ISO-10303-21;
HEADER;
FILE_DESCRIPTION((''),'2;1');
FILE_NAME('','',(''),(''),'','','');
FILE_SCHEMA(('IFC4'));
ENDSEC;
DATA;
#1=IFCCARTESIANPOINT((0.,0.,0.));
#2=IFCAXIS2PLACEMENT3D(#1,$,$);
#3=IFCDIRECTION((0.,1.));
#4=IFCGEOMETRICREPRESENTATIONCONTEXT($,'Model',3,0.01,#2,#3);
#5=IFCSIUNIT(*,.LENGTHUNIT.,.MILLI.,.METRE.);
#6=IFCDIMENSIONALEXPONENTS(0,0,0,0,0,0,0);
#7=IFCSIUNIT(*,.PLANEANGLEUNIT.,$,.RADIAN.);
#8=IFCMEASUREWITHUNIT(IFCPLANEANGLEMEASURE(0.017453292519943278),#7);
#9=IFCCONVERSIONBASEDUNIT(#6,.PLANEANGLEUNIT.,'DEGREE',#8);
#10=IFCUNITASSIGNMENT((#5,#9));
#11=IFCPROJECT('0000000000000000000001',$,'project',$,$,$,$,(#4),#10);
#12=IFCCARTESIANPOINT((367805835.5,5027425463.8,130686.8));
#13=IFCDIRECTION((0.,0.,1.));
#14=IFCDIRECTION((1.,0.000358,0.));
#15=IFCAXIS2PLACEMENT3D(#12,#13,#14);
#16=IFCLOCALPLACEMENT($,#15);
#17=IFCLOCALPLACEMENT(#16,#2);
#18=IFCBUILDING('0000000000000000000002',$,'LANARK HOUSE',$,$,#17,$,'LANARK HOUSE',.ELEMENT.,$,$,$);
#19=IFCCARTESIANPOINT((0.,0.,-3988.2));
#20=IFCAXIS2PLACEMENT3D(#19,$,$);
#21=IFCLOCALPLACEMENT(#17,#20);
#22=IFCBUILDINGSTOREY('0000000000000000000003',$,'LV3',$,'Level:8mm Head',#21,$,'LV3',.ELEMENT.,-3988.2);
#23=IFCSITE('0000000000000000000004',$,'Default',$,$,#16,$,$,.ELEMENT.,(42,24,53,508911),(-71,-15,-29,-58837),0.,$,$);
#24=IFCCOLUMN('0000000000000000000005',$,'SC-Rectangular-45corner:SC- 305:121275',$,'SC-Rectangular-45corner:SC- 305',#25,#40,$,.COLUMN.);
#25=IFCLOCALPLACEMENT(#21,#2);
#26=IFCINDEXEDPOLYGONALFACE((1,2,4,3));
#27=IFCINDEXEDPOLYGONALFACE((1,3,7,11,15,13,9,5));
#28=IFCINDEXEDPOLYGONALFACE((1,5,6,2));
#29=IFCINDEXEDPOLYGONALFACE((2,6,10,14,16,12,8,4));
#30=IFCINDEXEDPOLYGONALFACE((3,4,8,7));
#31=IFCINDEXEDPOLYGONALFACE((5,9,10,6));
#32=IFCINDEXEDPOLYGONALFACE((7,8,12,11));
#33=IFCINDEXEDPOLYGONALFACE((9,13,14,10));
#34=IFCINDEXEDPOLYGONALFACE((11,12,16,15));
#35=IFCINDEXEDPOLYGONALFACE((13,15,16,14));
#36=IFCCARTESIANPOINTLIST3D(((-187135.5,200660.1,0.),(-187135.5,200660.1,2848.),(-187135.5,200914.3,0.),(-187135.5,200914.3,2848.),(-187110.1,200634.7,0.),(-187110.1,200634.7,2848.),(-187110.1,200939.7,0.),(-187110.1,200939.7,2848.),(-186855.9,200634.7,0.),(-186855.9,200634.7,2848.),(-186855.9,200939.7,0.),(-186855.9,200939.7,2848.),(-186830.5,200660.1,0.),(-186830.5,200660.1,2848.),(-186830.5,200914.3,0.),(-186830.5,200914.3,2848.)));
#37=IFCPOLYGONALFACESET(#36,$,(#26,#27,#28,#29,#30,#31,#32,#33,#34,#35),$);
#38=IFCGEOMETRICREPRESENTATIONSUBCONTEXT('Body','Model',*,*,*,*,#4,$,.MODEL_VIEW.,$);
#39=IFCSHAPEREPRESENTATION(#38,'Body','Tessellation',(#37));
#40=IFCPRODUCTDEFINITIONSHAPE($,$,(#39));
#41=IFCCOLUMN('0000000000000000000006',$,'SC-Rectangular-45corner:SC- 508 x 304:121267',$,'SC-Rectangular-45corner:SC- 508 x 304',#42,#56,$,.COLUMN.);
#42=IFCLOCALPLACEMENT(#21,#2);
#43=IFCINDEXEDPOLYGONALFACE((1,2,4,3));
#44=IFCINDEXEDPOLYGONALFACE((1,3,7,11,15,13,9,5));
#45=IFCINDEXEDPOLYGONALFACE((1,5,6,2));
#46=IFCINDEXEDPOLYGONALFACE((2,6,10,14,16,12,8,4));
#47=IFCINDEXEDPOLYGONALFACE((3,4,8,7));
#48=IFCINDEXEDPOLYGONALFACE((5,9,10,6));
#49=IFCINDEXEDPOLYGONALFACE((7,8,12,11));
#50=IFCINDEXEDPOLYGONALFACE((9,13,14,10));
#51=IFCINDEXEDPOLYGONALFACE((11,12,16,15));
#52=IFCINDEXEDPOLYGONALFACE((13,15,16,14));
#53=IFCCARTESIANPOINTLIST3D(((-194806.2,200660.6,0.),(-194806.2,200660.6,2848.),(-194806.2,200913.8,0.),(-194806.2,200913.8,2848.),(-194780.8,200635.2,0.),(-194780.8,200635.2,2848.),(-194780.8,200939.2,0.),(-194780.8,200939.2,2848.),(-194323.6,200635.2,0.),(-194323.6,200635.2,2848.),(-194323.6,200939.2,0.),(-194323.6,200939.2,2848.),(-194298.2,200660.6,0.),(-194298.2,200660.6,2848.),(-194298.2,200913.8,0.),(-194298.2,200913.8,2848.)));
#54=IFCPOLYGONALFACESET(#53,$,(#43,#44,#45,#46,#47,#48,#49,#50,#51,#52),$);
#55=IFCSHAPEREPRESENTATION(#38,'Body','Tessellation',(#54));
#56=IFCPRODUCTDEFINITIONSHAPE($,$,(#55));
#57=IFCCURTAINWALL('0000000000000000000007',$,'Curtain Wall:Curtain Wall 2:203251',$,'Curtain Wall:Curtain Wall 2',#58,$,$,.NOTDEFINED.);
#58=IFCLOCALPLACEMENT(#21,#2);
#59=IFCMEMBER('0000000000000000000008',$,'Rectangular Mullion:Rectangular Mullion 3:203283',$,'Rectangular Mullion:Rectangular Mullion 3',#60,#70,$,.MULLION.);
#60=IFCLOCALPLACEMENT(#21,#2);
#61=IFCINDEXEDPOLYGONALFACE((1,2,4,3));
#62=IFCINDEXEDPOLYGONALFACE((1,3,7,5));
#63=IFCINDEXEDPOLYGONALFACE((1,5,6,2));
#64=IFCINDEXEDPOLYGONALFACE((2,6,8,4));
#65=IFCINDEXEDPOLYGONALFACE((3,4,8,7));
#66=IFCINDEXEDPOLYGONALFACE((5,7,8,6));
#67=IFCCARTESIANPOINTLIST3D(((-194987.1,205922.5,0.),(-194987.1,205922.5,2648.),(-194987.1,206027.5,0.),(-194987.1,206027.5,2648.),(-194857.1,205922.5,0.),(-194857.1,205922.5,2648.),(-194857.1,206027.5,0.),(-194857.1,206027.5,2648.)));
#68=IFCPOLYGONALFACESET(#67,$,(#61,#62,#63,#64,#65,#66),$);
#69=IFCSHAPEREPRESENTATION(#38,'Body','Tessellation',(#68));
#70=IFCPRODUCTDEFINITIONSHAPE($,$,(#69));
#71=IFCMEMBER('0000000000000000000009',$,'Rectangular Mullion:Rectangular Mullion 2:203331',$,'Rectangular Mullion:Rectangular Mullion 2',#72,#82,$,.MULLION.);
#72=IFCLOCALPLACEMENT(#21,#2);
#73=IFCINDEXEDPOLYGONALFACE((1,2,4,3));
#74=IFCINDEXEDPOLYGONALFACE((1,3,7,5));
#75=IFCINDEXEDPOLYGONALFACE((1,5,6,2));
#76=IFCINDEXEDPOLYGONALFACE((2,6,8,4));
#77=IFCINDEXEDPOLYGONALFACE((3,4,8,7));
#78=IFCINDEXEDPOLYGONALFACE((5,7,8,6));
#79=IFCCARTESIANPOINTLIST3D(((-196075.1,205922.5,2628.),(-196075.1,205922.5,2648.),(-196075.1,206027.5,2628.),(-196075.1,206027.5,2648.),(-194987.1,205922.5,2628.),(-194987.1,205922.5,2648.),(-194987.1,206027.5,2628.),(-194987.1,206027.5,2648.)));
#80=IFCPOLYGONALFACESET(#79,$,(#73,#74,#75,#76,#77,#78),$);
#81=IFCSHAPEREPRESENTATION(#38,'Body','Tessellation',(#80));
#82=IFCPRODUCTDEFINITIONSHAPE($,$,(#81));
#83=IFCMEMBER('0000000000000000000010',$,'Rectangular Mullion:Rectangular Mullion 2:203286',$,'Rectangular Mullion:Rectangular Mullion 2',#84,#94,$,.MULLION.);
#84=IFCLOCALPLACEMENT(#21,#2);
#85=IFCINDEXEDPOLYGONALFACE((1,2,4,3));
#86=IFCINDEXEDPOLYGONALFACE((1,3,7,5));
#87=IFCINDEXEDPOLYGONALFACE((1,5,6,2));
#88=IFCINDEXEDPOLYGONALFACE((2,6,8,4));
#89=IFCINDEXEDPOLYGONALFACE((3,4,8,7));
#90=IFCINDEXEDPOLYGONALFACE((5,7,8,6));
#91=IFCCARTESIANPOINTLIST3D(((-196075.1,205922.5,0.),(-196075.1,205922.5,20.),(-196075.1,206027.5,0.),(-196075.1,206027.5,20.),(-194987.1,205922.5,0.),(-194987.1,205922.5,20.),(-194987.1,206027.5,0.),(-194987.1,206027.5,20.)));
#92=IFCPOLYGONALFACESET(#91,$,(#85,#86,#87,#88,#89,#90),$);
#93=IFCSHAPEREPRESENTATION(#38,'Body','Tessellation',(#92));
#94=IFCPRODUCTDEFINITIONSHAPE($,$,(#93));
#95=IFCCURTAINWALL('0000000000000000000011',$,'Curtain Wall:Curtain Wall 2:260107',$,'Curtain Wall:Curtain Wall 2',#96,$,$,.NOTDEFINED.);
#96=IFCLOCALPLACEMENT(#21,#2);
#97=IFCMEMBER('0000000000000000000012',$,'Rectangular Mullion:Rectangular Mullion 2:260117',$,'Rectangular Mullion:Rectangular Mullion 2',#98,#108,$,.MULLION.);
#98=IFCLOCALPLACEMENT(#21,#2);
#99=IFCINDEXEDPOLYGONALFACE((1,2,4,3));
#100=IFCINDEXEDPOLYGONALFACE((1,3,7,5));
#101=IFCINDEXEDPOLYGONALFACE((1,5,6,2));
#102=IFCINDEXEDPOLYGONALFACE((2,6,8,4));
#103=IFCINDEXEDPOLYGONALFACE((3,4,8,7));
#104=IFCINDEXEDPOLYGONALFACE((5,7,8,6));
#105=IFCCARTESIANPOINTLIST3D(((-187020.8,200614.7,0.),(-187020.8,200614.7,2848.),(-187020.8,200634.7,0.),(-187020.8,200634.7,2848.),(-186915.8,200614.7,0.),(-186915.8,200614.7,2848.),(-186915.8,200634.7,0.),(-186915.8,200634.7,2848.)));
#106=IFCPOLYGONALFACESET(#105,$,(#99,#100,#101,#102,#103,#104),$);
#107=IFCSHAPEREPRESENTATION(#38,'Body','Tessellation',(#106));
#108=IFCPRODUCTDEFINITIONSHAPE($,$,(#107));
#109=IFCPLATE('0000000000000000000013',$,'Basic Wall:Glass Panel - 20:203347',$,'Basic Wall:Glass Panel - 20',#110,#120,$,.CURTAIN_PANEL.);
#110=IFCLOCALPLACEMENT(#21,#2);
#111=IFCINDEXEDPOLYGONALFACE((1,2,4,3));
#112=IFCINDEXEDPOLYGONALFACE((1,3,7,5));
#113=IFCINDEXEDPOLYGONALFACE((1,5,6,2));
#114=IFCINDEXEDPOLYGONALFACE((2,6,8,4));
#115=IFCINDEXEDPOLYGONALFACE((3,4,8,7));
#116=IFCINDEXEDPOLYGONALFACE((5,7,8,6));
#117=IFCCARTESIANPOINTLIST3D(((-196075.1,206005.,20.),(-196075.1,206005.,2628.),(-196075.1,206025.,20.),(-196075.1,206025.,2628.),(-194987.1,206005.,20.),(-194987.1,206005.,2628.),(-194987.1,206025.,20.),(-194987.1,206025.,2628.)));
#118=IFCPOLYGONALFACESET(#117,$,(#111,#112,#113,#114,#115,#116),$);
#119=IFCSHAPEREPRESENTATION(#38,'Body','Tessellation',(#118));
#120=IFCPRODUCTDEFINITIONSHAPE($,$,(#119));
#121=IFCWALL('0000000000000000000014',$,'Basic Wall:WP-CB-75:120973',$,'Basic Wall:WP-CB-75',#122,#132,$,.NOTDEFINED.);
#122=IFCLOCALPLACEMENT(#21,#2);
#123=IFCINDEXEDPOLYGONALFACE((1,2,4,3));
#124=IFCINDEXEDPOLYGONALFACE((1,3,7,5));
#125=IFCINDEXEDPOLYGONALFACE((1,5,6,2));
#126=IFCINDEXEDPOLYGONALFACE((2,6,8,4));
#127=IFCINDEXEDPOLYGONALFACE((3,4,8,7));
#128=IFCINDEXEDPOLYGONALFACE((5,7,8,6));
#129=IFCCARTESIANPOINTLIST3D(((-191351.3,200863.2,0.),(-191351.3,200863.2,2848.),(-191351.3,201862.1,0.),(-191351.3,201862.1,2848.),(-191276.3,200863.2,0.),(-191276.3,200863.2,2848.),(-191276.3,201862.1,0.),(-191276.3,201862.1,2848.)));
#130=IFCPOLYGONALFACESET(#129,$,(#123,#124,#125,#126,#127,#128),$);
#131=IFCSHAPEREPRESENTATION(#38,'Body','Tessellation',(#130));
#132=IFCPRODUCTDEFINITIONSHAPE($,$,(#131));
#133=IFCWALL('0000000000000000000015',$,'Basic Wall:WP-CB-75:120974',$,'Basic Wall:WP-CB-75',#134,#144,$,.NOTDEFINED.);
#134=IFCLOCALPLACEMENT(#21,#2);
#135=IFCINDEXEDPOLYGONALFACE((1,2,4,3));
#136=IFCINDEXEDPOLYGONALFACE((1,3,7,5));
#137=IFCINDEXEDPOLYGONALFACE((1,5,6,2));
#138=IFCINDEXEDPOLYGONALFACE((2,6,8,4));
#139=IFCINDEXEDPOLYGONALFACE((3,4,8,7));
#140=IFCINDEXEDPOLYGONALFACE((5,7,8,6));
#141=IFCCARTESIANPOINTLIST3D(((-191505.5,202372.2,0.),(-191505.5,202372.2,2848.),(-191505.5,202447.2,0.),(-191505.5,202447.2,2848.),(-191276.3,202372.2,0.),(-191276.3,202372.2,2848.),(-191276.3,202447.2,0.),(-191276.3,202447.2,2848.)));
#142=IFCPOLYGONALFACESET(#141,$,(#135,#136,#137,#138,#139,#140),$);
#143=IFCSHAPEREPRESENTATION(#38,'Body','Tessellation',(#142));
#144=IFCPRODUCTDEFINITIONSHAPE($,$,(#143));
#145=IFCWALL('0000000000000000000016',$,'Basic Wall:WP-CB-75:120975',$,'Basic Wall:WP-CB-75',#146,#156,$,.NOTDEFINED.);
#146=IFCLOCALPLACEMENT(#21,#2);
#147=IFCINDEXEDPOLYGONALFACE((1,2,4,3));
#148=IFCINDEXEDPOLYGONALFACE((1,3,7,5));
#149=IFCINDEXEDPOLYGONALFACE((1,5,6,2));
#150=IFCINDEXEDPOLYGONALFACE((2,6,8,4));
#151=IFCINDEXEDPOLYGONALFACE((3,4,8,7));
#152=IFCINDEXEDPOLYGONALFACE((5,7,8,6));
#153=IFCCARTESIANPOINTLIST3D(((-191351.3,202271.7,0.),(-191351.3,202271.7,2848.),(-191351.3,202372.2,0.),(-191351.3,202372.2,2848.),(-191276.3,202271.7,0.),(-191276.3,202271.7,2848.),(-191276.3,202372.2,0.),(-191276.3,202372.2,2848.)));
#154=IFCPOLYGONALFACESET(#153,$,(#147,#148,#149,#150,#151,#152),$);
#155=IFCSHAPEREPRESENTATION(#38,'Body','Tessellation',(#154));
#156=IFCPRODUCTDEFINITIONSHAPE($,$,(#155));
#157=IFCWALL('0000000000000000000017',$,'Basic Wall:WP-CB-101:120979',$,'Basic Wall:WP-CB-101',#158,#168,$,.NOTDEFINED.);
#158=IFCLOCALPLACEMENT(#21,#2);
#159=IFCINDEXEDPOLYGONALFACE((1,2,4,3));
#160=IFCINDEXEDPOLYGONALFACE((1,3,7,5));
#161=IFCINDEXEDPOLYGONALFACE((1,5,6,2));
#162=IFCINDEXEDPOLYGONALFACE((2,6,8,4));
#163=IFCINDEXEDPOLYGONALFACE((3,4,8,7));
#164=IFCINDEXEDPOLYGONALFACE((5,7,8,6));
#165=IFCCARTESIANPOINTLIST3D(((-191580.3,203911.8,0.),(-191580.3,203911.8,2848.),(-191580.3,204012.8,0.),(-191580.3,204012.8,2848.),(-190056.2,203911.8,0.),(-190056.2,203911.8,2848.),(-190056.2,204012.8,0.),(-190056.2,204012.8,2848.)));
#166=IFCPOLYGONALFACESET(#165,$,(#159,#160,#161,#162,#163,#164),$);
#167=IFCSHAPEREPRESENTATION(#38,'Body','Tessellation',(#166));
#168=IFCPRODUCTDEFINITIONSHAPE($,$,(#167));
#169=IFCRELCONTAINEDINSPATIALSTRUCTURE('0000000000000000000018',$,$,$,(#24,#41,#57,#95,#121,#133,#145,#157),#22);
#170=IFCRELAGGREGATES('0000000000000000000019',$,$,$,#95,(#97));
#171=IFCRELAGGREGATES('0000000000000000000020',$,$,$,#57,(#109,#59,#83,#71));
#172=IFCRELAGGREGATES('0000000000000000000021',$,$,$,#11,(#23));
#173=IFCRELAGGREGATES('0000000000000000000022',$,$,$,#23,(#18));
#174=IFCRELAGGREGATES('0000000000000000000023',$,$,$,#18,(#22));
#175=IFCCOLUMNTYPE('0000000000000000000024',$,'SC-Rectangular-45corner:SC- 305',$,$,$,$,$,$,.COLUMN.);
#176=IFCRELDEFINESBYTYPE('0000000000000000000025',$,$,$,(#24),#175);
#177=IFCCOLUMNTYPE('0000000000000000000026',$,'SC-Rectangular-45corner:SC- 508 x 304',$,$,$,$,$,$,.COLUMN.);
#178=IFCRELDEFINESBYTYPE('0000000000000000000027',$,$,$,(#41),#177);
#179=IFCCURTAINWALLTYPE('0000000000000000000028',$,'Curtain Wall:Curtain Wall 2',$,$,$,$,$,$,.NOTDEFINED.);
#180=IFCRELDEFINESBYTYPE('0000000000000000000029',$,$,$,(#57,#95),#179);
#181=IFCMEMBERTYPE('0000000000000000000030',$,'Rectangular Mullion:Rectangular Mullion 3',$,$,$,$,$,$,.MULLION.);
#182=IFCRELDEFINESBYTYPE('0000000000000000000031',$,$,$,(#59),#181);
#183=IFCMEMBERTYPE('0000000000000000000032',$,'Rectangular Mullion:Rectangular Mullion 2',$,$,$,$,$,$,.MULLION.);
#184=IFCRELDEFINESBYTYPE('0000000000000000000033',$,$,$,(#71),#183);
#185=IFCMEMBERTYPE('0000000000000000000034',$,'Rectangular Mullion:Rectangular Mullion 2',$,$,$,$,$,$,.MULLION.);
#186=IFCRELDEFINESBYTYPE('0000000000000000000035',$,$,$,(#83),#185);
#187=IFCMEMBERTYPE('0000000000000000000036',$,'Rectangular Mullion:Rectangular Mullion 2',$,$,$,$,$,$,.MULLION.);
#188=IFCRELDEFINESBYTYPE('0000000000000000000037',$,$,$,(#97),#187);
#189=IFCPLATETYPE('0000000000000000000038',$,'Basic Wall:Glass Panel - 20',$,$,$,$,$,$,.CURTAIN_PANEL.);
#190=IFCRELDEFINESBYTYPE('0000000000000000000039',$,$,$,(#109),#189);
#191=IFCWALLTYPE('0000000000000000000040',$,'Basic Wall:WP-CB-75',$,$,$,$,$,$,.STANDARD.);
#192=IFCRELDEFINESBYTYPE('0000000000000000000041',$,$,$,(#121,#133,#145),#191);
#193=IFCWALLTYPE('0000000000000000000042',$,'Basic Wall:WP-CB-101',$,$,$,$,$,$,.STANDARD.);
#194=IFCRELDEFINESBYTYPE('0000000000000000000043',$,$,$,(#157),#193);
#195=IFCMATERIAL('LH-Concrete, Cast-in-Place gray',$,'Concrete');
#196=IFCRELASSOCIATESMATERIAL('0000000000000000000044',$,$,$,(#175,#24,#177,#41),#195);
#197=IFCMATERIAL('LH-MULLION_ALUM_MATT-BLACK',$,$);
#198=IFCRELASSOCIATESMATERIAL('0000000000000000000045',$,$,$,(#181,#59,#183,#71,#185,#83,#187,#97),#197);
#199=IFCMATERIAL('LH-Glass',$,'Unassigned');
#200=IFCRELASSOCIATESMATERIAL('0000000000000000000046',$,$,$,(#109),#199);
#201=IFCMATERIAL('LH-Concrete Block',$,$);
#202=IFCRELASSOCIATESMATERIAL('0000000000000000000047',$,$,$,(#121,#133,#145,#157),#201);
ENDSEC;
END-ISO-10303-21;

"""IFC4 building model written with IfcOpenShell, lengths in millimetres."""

from ifc_helpers import new_model, entity, si_unit, converted_unit, direction, frame, origin, place, context, subcontext, project, spatial, indexed_curve, outline, extrude, source, transform, mapped, material, type_object, type_shapes, element, aggregate, save


model = new_model("IFC4")

# Units and contexts
model_context = context("Model", 3, precision=0.01, world=origin(), true_north=direction((0.0, 1.0)))
body_context = subcontext(model_context, "Body", "Model", "MODEL_VIEW")
ifc_project = project(units=[si_unit("LENGTHUNIT", "METRE", prefix="MILLI"), converted_unit("PLANEANGLEUNIT", "DEGREE", entity("IfcPlaneAngleMeasure", 0.017453292519943278), si_unit("PLANEANGLEUNIT", "RADIAN"), dimensions=[0, 0, 0, 0, 0, 0, 0])], contexts=[model_context])

# Site, building, storey
site_placement = place(None, frame((367805835.5, 5027425463.8, 130686.8), z_axis=(0.0, 0.0, 1.0), x_axis=(1.0, 0.000358, 0.0)))
site = spatial("IfcSite", under=ifc_project, at=site_placement, Name="Default", CompositionType="ELEMENT", RefLatitude=(42, 24, 53, 508911), RefLongitude=(-71, -15, -29, -58837), RefElevation=0.0)
building_placement = place(site_placement, origin())
building = spatial("IfcBuilding", under=site, at=building_placement, Name="LANARK HOUSE", LongName="LANARK HOUSE", CompositionType="ELEMENT")
storey_placement = place(building_placement, frame((0.0, 0.0, -3988.2)))
storey = spatial("IfcBuildingStorey", under=building, at=storey_placement, Name="LV3", ObjectType="Level:8mm Head", LongName="LV3", CompositionType="ELEMENT", Elevation=-3988.2)

# Columns
ifc_material_1 = material(Name="LH-Concrete, Cast-in-Place gray", Category="Concrete")
column_type_1 = type_object("IfcColumnType", Name="SC-Rectangular-45corner:SC- 305", PredefinedType="COLUMN", material=ifc_material_1)
shared_shape_1 = source(origin(), body_context, "Body", "SweptSolid", [
    extrude(outline(indexed_curve([(-127.1, -152.5), (127.1, -152.5), (152.5, -127.1), (152.5, 127.1), (127.1, 152.5), (-127.1, 152.5), (-152.5, 127.1), (-152.5, -127.1), (-127.1, -152.5)], self_intersect=False)), frame((0.0, 0.0, -3988.2), z_axis=(0.0, 0.0, 1.0), x_axis=(-1.0, 0.0, 0.0)), (0.0, 0.0, 1.0), 2848.0),
])
type_shapes(column_type_1, [shared_shape_1])
column_1_placement = place(storey_placement, frame((-186983.0, 200787.2, 3988.2)))
element("IfcColumn", 1, at=column_1_placement, inside=storey, type_object=column_type_1, material=ifc_material_1, Name="SC-Rectangular-45corner:SC- 305:121275", ObjectType="SC-Rectangular-45corner:SC- 305", PredefinedType="COLUMN", context=body_context, shape_type="MappedRepresentation", body=[
    mapped(shared_shape_1, transform((0.0, 0.0, 0.0), scale=1.0)),
])
column_type_2 = type_object("IfcColumnType", Name="SC-Rectangular-45corner:SC- 508 x 304", PredefinedType="COLUMN", material=ifc_material_1)
shared_shape_2 = source(origin(), body_context, "Body", "SweptSolid", [
    extrude(outline(indexed_curve([(-228.6, -152.0), (228.6, -152.0), (254.0, -126.6), (254.0, 126.6), (228.6, 152.0), (-228.6, 152.0), (-254.0, 126.6), (-254.0, -126.6), (-228.6, -152.0)], self_intersect=False)), frame((0.0, 0.0, -3988.2), z_axis=(0.0, 0.0, 1.0), x_axis=(-1.0, 0.0, 0.0)), (0.0, 0.0, 1.0), 2848.0),
])
type_shapes(column_type_2, [shared_shape_2])
column_2_placement = place(storey_placement, frame((-194552.2, 200787.2, 3988.2)))
element("IfcColumn", 2, at=column_2_placement, inside=storey, type_object=column_type_2, material=ifc_material_1, Name="SC-Rectangular-45corner:SC- 508 x 304:121267", ObjectType="SC-Rectangular-45corner:SC- 508 x 304", PredefinedType="COLUMN", context=body_context, shape_type="MappedRepresentation", body=[
    mapped(shared_shape_2, transform((0.0, 0.0, 0.0), scale=1.0)),
])

# Curtain wall, members
curtain_wall_type = type_object("IfcCurtainWallType", Name="Curtain Wall:Curtain Wall 2", PredefinedType="NOTDEFINED")
curtain_wall_1_placement = place(storey_placement, frame((0.0, 0.0, 3988.2)))
curtain_wall_1 = element("IfcCurtainWall", 3, at=curtain_wall_1_placement, inside=storey, type_object=curtain_wall_type, Name="Curtain Wall:Curtain Wall 2:203251", ObjectType="Curtain Wall:Curtain Wall 2", PredefinedType="NOTDEFINED")
ifc_material_2 = material(Name="LH-MULLION_ALUM_MATT-BLACK")
member_type_1 = type_object("IfcMemberType", Name="Rectangular Mullion:Rectangular Mullion 3", PredefinedType="MULLION", material=ifc_material_2)
shared_shape_3 = source(origin(), body_context, "Body", "SweptSolid", [
    extrude(outline(indexed_curve([(-65.0, -52.5), (65.0, -52.5), (65.0, 52.5), (-65.0, 52.5), (-65.0, -52.5)], self_intersect=False)), frame((-65.0, -40.0, -2648.0), z_axis=(0.0, 0.0, 1.0), x_axis=(-1.0, 0.0, 0.0)), (0.0, 0.0, 1.0), 2648.0),
])
type_shapes(member_type_1, [shared_shape_3])
member_1_placement = place(curtain_wall_1_placement, frame((-194857.1, 206015.0, -1340.2)))
member_1 = element("IfcMember", 4, at=member_1_placement, type_object=member_type_1, material=ifc_material_2, Name="Rectangular Mullion:Rectangular Mullion 3:203283", ObjectType="Rectangular Mullion:Rectangular Mullion 3", PredefinedType="MULLION", context=body_context, shape_type="MappedRepresentation", body=[
    mapped(shared_shape_3, transform((0.0, 0.0, 0.0), scale=1.0)),
])
member_type_2 = type_object("IfcMemberType", Name="Rectangular Mullion:Rectangular Mullion 2", PredefinedType="MULLION", material=ifc_material_2)
shared_shape_4 = source(origin(), body_context, "Body", "SweptSolid", [
    extrude(outline(indexed_curve([(-10.0, -52.5), (10.0, -52.5), (10.0, 52.5), (-10.0, 52.5), (-10.0, -52.5)], self_intersect=False)), frame((-10.0, -40.0, -1088.0), z_axis=(0.0, 0.0, 1.0), x_axis=(-1.0, 0.0, 0.0)), (0.0, 0.0, 1.0), 1088.0),
])
type_shapes(member_type_2, [shared_shape_4])
member_2_placement = place(curtain_wall_1_placement, frame((-196075.1, 206015.0, -1340.2), z_axis=(-1.0, 0.0, 0.0), x_axis=(0.0, 0.0, 1.0)))
member_2 = element("IfcMember", 5, at=member_2_placement, type_object=member_type_2, material=ifc_material_2, Name="Rectangular Mullion:Rectangular Mullion 2:203331", ObjectType="Rectangular Mullion:Rectangular Mullion 2", PredefinedType="MULLION", context=body_context, shape_type="MappedRepresentation", body=[
    mapped(shared_shape_4, transform((0.0, 0.0, 0.0), scale=1.0)),
])
member_type_3 = type_object("IfcMemberType", Name="Rectangular Mullion:Rectangular Mullion 2", PredefinedType="MULLION", material=ifc_material_2)
shared_shape_5 = source(origin(), body_context, "Body", "SweptSolid", [
    extrude(outline(indexed_curve([(-10.0, -52.5), (10.0, -52.5), (10.0, 52.5), (-10.0, 52.5), (-10.0, -52.5)], self_intersect=False)), frame((-10.0, -40.0, -1088.0), z_axis=(0.0, 0.0, 1.0), x_axis=(-1.0, 0.0, 0.0)), (0.0, 0.0, 1.0), 1088.0),
])
type_shapes(member_type_3, [shared_shape_5])
member_3_placement = place(curtain_wall_1_placement, frame((-194987.1, 206015.0, -3988.2), z_axis=(1.0, 0.0, 0.0), x_axis=(0.0, 0.0, -1.0)))
member_3 = element("IfcMember", 6, at=member_3_placement, type_object=member_type_3, material=ifc_material_2, Name="Rectangular Mullion:Rectangular Mullion 2:203286", ObjectType="Rectangular Mullion:Rectangular Mullion 2", PredefinedType="MULLION", context=body_context, shape_type="MappedRepresentation", body=[
    mapped(shared_shape_5, transform((0.0, 0.0, 0.0), scale=1.0)),
])

# Curtain wall, member
curtain_wall_2_placement = place(storey_placement, frame((0.0, 0.0, 3988.2)))
curtain_wall_2 = element("IfcCurtainWall", 7, at=curtain_wall_2_placement, inside=storey, type_object=curtain_wall_type, Name="Curtain Wall:Curtain Wall 2:260107", ObjectType="Curtain Wall:Curtain Wall 2", PredefinedType="NOTDEFINED")
member_type_4 = type_object("IfcMemberType", Name="Rectangular Mullion:Rectangular Mullion 2", PredefinedType="MULLION", material=ifc_material_2)
shared_shape_6 = source(origin(), body_context, "Body", "SweptSolid", [
    extrude(outline(indexed_curve([(-10.0, -52.5), (10.0, -52.5), (10.0, 52.5), (-10.0, 52.5), (-10.0, -52.5)], self_intersect=False)), frame((-10.0, -40.0, -2848.0), z_axis=(0.0, 0.0, 1.0), x_axis=(-1.0, 0.0, 0.0)), (0.0, 0.0, 1.0), 2848.0),
])
type_shapes(member_type_4, [shared_shape_6])
member_4_placement = place(curtain_wall_2_placement, frame((-187008.3, 200634.7, -1140.2), z_axis=(0.0, 0.0, 1.0), x_axis=(0.0, 1.0, 0.0)))
member_4 = element("IfcMember", 8, at=member_4_placement, type_object=member_type_4, material=ifc_material_2, Name="Rectangular Mullion:Rectangular Mullion 2:260117", ObjectType="Rectangular Mullion:Rectangular Mullion 2", PredefinedType="MULLION", context=body_context, shape_type="MappedRepresentation", body=[
    mapped(shared_shape_6, transform((0.0, 0.0, 0.0), scale=1.0)),
])
aggregate(curtain_wall_2, [member_4])

# Plate
ifc_material_3 = material(Name="LH-Glass", Category="Unassigned")
plate_type = type_object("IfcPlateType", Name="Basic Wall:Glass Panel - 20", PredefinedType="CURTAIN_PANEL")
plate_placement = place(storey_placement, frame((-194987.1, 206015.0, 20.0), z_axis=(0.0, 0.0, 1.0), x_axis=(-1.0, 0.0, 0.0)))
plate = element("IfcPlate", 9, at=plate_placement, type_object=plate_type, material=ifc_material_3, Name="Basic Wall:Glass Panel - 20:203347", ObjectType="Basic Wall:Glass Panel - 20", PredefinedType="CURTAIN_PANEL", context=body_context, shape_type="SweptSolid", body=[
    extrude(outline(indexed_curve([(-10.0, -544.0), (10.0, -544.0), (10.0, 544.0), (-10.0, 544.0), (-10.0, -544.0)], self_intersect=False)), frame((544.0, 0.0, 0.0), z_axis=(0.0, 0.0, 1.0), x_axis=(0.0, 1.0, 0.0)), (0.0, 0.0, 1.0), 2608.0),
])
aggregate(curtain_wall_1, [plate, member_1, member_3, member_2])

# Walls
ifc_material_4 = material(Name="LH-Concrete Block")
wall_type_1 = type_object("IfcWallType", Name="Basic Wall:WP-CB-75", PredefinedType="STANDARD")
wall_1_placement = place(storey_placement, frame((-191313.8, 200863.2, 0.0), z_axis=(0.0, 0.0, 1.0), x_axis=(0.0, 1.0, 0.0)))
element("IfcWall", 10, at=wall_1_placement, inside=storey, type_object=wall_type_1, material=ifc_material_4, Name="Basic Wall:WP-CB-75:120973", ObjectType="Basic Wall:WP-CB-75", PredefinedType="NOTDEFINED", context=body_context, shape_type="SweptSolid", body=[
    extrude(outline(indexed_curve([(998.9, 37.5), (0.0, 37.5), (0.0, -37.5), (998.9, -37.5), (998.9, 37.5)], self_intersect=False)), origin(), (0.0, 0.0, 1.0), 2848.0),
])
wall_2_placement = place(storey_placement, frame((-191505.5, 202409.7, 0.0)))
element("IfcWall", 11, at=wall_2_placement, inside=storey, type_object=wall_type_1, material=ifc_material_4, Name="Basic Wall:WP-CB-75:120974", ObjectType="Basic Wall:WP-CB-75", PredefinedType="NOTDEFINED", context=body_context, shape_type="SweptSolid", body=[
    extrude(outline(indexed_curve([(229.2, 37.5), (0.0, 37.5), (0.0, -37.5), (229.2, -37.5), (229.2, 37.5)], self_intersect=False)), origin(), (0.0, 0.0, 1.0), 2848.0),
])
wall_3_placement = place(storey_placement, frame((-191313.8, 202372.2, 0.0), z_axis=(0.0, 0.0, 1.0), x_axis=(0.0, -1.0, 0.0)))
element("IfcWall", 12, at=wall_3_placement, inside=storey, type_object=wall_type_1, material=ifc_material_4, Name="Basic Wall:WP-CB-75:120975", ObjectType="Basic Wall:WP-CB-75", PredefinedType="NOTDEFINED", context=body_context, shape_type="SweptSolid", body=[
    extrude(outline(indexed_curve([(100.5, 37.5), (0.0, 37.5), (0.0, -37.5), (100.5, -37.5), (100.5, 37.5)], self_intersect=False)), origin(), (0.0, 0.0, 1.0), 2848.0),
])
wall_type_2 = type_object("IfcWallType", Name="Basic Wall:WP-CB-101", PredefinedType="STANDARD")
wall_4_placement = place(storey_placement, frame((-190056.2, 203962.3, 0.0), z_axis=(0.0, 0.0, 1.0), x_axis=(-1.0, 0.0, 0.0)))
element("IfcWall", 13, at=wall_4_placement, inside=storey, type_object=wall_type_2, material=ifc_material_4, Name="Basic Wall:WP-CB-101:120979", ObjectType="Basic Wall:WP-CB-101", PredefinedType="NOTDEFINED", context=body_context, shape_type="SweptSolid", body=[
    extrude(outline(indexed_curve([(1524.1, 50.5), (0.0, 50.5), (0.0, -50.5), (1524.1, -50.5), (1524.1, 50.5)], self_intersect=False)), origin(), (0.0, 0.0, 1.0), 2848.0),
])

save(model, "model.ifc")
